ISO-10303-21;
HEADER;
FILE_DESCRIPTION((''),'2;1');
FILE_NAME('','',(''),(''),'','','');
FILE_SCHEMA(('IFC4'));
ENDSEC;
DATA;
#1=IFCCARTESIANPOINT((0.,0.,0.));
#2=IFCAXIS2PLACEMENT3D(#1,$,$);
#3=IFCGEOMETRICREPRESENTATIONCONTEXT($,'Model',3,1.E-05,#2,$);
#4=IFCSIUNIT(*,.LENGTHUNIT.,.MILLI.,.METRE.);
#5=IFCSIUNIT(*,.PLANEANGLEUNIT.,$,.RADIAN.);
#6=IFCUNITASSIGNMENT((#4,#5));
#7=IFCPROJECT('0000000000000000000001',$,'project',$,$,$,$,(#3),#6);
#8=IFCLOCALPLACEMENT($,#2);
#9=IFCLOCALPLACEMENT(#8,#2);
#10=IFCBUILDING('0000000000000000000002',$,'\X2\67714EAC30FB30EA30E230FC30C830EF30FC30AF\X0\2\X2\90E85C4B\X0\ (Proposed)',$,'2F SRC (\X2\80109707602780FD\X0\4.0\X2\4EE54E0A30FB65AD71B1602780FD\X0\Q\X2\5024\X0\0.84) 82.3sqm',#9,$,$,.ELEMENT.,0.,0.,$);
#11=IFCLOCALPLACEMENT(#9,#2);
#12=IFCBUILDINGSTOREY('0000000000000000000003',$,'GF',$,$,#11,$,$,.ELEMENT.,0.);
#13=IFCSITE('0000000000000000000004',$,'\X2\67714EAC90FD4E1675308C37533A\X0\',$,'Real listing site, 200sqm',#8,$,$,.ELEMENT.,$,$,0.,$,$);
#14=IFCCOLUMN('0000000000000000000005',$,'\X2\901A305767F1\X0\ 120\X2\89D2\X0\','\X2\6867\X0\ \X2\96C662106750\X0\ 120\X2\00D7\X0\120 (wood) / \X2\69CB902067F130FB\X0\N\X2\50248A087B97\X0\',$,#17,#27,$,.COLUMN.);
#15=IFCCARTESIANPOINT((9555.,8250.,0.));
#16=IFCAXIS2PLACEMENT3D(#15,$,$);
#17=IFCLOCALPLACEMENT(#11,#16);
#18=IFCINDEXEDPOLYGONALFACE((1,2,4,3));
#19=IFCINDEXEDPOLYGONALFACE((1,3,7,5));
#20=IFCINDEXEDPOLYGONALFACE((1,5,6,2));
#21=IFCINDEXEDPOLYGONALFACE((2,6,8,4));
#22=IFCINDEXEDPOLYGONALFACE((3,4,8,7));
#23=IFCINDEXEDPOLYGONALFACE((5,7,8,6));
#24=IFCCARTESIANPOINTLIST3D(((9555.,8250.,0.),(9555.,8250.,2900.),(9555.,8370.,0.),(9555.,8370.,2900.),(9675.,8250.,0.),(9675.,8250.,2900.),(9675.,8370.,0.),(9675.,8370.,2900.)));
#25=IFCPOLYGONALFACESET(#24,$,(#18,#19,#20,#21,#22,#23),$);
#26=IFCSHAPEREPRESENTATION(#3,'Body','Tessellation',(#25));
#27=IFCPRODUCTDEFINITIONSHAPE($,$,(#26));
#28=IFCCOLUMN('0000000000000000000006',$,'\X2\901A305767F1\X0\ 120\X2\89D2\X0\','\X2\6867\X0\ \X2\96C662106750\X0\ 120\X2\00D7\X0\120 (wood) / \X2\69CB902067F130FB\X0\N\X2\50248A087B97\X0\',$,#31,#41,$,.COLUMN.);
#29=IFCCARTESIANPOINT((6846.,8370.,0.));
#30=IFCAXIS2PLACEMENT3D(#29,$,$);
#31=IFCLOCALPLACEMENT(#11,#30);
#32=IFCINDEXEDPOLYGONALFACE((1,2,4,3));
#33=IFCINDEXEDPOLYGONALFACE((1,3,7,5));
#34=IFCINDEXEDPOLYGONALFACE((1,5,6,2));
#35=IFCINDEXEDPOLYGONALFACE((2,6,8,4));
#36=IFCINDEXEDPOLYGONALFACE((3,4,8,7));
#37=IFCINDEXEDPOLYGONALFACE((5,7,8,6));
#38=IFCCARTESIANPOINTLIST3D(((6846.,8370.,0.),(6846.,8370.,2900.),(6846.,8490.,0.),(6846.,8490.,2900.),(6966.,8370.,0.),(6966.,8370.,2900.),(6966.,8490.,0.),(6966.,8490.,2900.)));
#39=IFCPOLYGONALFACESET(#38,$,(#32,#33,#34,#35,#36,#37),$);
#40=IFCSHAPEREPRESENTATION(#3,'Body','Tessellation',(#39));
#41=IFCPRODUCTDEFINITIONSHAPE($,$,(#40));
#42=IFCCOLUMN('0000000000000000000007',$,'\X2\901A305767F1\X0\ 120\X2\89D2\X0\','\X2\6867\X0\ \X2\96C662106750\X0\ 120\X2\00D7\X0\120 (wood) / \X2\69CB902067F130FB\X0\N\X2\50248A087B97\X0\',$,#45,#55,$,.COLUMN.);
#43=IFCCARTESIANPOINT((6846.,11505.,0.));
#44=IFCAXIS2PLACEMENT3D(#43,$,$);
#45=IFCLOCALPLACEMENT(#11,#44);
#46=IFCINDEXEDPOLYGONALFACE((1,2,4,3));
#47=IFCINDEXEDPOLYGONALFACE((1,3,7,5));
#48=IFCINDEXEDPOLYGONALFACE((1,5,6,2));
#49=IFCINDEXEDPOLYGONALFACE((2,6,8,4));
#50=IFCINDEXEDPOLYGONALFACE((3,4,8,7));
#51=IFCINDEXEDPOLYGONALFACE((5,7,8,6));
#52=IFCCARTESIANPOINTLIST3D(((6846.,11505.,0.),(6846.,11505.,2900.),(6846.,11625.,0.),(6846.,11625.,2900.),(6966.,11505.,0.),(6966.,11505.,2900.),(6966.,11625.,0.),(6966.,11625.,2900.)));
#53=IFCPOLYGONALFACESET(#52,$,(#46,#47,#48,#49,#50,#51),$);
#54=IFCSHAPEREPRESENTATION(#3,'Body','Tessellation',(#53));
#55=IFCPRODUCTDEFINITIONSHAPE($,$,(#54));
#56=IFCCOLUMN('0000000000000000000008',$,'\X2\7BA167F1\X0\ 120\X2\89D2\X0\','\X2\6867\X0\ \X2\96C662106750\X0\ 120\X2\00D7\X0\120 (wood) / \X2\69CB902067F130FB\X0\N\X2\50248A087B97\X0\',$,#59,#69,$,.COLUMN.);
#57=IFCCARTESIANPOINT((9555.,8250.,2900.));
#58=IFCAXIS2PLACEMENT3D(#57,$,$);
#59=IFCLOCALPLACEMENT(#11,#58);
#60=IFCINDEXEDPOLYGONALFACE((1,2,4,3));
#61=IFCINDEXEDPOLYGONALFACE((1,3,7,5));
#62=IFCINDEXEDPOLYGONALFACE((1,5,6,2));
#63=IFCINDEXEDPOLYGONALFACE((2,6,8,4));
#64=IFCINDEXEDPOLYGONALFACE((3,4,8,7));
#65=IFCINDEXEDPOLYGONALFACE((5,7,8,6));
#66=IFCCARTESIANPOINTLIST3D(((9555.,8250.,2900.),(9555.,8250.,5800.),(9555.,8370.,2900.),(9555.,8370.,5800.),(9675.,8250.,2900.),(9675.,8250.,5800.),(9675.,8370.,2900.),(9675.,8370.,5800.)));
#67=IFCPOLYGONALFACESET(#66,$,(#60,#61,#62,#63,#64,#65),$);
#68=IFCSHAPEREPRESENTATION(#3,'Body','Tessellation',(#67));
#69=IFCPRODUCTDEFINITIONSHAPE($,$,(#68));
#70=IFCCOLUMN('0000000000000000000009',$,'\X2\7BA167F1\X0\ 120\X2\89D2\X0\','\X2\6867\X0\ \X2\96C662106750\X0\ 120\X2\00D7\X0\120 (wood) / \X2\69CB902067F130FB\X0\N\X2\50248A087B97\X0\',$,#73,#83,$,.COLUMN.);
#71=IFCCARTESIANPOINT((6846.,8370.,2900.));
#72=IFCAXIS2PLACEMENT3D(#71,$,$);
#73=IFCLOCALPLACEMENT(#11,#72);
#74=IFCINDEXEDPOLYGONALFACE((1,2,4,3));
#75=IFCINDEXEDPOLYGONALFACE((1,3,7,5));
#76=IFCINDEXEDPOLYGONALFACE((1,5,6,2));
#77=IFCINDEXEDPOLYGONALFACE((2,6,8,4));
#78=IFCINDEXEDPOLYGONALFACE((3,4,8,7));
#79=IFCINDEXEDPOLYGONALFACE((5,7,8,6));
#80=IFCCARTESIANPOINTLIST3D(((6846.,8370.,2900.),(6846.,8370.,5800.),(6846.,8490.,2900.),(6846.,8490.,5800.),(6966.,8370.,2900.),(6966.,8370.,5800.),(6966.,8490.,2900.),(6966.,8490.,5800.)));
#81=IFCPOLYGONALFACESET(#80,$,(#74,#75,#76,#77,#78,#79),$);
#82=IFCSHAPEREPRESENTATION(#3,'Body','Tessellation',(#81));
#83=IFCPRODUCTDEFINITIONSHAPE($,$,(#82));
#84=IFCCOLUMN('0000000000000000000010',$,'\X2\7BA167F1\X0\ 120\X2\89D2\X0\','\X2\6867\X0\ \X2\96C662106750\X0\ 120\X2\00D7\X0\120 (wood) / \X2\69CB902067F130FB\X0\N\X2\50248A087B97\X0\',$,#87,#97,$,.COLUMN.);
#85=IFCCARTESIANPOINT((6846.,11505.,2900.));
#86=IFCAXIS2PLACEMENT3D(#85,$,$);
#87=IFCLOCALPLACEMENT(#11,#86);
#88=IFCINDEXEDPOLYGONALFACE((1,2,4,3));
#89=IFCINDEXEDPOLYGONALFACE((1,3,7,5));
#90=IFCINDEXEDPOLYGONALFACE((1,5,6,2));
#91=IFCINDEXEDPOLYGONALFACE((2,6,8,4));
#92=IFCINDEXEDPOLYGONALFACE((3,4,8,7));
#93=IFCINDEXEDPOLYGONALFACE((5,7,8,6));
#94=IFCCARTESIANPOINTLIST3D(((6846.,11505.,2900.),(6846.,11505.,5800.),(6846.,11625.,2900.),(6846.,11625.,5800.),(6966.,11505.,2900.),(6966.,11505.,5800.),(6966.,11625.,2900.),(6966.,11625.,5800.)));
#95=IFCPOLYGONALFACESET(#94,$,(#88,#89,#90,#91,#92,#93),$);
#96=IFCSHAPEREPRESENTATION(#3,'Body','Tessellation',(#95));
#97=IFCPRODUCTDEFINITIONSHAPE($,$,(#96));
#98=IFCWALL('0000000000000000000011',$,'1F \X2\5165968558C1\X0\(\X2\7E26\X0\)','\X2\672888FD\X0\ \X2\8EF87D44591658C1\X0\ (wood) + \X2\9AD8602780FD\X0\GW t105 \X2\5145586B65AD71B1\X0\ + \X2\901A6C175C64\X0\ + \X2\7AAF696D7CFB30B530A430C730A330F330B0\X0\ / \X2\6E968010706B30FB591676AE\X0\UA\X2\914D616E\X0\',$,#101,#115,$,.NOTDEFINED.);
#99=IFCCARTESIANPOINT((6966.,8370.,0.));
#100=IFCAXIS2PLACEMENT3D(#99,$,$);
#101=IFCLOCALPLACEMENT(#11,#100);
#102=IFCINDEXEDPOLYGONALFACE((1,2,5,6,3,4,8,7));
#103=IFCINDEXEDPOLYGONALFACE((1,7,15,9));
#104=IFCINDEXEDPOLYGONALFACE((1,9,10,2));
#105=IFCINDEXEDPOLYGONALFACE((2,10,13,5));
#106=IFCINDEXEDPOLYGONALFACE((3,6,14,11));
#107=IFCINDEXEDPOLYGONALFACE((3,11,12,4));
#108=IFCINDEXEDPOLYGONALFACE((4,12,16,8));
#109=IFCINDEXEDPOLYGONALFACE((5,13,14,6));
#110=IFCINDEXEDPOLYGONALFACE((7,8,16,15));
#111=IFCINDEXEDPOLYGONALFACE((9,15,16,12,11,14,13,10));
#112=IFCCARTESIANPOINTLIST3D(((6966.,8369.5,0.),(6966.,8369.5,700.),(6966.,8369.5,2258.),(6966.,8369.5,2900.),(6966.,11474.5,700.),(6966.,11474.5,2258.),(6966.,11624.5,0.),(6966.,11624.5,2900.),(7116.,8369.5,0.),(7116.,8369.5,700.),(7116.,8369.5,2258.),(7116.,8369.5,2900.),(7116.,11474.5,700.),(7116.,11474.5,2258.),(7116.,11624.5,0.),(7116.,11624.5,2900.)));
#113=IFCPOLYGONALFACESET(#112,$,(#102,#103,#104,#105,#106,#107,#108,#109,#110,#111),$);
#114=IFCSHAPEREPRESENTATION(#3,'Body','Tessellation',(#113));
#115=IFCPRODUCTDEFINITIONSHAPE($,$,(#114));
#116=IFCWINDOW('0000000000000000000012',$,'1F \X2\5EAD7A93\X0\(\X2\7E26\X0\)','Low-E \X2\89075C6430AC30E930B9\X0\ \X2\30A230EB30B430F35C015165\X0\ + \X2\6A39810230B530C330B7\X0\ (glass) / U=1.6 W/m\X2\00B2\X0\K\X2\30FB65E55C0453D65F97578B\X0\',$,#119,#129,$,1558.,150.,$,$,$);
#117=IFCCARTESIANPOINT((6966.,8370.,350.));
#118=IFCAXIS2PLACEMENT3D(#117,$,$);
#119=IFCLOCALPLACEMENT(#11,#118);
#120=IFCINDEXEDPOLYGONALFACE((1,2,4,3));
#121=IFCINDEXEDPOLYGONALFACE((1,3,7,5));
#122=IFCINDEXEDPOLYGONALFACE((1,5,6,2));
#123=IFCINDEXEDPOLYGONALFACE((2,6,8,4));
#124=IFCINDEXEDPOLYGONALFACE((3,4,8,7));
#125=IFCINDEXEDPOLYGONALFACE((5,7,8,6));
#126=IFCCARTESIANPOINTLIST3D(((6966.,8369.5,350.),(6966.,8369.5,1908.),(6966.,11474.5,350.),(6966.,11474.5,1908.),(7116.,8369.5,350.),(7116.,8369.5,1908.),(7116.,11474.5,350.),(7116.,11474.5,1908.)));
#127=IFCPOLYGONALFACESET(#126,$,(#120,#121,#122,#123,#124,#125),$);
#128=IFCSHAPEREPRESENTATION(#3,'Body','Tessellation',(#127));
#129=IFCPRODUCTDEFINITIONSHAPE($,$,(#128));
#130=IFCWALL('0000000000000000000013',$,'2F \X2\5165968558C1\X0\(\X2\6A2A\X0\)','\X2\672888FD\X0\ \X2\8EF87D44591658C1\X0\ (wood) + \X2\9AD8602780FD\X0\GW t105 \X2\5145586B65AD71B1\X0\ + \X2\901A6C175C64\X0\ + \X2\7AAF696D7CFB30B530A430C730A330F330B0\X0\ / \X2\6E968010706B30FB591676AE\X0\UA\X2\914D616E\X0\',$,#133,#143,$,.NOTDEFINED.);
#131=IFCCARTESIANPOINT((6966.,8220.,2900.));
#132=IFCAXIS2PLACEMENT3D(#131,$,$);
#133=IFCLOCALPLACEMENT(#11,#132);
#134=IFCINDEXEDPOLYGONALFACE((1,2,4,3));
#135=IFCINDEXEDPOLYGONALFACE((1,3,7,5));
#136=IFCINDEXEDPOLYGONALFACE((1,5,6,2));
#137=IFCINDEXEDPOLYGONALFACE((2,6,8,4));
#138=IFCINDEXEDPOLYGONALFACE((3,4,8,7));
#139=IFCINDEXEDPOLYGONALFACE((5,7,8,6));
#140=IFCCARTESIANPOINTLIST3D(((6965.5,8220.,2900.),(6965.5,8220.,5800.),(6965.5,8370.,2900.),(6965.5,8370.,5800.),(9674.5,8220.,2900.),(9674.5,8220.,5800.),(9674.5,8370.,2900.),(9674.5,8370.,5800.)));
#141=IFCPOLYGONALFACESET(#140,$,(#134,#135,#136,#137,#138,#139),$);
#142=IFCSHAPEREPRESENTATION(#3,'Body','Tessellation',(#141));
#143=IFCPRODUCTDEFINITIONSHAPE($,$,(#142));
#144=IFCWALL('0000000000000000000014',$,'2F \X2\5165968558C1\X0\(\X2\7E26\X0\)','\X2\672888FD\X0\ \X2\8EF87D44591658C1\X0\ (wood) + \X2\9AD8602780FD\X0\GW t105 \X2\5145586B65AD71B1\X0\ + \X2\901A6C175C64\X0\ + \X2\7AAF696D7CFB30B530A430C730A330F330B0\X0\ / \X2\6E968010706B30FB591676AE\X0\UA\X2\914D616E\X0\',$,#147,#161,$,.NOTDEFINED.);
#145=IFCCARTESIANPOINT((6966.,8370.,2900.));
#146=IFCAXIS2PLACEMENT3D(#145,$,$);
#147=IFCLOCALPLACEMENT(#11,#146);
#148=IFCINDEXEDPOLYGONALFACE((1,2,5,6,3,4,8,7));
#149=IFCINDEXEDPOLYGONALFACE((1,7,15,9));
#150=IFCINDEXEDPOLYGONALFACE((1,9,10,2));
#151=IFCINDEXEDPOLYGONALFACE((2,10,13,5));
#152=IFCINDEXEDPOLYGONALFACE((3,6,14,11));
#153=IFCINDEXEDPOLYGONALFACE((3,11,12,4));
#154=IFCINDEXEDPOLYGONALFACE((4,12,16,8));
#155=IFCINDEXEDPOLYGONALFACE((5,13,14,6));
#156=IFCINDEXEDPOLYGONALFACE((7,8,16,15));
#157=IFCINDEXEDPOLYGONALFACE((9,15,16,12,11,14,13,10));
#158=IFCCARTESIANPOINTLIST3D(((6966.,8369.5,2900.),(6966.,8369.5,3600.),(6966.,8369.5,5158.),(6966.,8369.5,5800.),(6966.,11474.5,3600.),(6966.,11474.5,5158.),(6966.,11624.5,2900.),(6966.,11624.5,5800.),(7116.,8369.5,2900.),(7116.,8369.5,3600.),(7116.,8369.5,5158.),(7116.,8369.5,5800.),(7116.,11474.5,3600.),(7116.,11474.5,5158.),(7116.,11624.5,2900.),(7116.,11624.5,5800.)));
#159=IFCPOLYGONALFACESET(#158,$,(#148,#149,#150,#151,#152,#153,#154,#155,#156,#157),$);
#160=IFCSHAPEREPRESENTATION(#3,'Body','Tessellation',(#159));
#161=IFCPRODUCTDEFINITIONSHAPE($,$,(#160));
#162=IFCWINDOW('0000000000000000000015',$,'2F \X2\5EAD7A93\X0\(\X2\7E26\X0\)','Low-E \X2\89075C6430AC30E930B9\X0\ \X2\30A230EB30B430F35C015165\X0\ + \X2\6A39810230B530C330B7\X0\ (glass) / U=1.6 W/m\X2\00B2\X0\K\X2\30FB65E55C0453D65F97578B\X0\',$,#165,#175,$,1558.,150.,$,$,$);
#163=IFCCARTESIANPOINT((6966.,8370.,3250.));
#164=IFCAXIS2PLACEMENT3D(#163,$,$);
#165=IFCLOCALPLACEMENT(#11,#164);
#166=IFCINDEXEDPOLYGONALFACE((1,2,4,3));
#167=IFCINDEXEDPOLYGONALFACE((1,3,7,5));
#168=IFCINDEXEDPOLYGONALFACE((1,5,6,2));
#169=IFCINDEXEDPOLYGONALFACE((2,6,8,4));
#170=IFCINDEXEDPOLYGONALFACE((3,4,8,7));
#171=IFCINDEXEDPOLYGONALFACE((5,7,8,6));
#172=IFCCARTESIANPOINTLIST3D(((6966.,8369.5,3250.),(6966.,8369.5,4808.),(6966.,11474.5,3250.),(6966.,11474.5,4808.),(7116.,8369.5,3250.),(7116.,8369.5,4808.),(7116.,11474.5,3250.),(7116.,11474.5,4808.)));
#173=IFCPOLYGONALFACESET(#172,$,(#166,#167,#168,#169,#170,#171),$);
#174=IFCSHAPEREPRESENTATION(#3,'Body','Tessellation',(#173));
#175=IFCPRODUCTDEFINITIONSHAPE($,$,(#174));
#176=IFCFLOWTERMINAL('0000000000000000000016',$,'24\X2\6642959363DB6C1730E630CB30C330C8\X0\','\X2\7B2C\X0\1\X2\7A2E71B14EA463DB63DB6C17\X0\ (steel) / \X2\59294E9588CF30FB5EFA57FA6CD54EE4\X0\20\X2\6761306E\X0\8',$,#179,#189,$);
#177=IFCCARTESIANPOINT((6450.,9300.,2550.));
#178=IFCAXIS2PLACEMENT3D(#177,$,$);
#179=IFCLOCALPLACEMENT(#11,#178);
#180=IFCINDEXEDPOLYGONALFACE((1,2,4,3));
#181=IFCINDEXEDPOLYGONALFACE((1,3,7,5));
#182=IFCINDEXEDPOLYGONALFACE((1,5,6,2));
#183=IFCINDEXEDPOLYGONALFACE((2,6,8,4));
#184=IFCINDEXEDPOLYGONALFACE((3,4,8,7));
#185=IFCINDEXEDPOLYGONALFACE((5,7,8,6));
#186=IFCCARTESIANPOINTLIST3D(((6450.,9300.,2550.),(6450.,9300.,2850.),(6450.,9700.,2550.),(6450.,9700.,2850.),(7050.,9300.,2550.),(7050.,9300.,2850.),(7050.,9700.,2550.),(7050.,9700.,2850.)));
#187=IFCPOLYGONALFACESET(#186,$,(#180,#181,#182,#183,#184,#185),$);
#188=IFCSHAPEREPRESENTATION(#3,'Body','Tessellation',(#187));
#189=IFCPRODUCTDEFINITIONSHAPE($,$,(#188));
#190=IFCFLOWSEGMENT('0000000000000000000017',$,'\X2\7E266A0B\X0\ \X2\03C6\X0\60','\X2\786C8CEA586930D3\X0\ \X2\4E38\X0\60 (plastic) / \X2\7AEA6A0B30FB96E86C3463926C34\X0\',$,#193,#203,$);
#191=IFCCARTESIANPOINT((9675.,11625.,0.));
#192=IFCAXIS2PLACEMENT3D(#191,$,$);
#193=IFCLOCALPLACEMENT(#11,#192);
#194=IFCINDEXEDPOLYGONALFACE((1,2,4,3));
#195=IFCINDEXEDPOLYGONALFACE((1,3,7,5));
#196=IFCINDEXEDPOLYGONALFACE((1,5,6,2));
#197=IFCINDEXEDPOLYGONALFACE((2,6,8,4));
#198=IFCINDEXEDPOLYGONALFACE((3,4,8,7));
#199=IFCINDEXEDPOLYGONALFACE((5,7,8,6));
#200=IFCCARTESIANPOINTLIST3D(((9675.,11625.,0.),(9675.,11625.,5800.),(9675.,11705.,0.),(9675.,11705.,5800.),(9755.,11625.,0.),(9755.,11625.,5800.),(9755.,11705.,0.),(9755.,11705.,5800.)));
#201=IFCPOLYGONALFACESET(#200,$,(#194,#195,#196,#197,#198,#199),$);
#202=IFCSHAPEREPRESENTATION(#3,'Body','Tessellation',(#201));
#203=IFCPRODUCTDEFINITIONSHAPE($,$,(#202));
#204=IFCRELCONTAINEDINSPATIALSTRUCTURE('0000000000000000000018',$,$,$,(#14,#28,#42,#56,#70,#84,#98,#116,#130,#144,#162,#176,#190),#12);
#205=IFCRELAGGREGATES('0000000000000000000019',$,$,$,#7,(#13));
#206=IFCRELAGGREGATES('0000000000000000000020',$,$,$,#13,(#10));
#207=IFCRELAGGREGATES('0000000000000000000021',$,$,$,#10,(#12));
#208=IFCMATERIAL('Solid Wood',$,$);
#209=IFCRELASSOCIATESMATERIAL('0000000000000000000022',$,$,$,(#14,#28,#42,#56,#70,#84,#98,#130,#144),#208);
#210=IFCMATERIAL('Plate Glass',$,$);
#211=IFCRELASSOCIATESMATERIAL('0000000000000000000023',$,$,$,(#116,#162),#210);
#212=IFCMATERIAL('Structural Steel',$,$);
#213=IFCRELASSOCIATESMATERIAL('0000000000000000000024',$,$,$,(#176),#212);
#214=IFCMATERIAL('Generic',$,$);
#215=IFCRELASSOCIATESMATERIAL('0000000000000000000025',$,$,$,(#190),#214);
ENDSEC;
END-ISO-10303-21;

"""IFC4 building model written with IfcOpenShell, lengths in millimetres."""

from ifc_helpers import new_model, si_unit, frame, frame_2d, origin, place, context, project, spatial, rectangle, extrude, material, element, fill, save


model = new_model("IFC4")

# Units and contexts
model_context = context("Model", 3, precision=1e-05, world=origin())
ifc_project = project(units=[si_unit("LENGTHUNIT", "METRE", prefix="MILLI"), si_unit("PLANEANGLEUNIT", "RADIAN")], contexts=[model_context])

# Site, building, storey
site_placement = place(None, origin())
site = spatial("IfcSite", under=ifc_project, at=site_placement, Name="東京都世田谷区", ObjectType="Real listing site, 200sqm", CompositionType="ELEMENT", RefElevation=0.0)
building_placement = place(site_placement, origin())
building = spatial("IfcBuilding", under=site, at=building_placement, Name="東京・リモートワーク2部屋 (Proposed)", ObjectType="2F SRC (耐震性能4.0以上・断熱性能Q値0.84) 82.3sqm", CompositionType="ELEMENT", ElevationOfRefHeight=0.0, ElevationOfTerrain=0.0)
storey_placement = place(building_placement, origin())
storey = spatial("IfcBuildingStorey", under=building, at=storey_placement, Name="GF", CompositionType="ELEMENT", Elevation=0.0)

# Columns
ifc_material_1 = material(Name="Solid Wood")
column_1_placement = place(storey_placement, frame((9555.0, 8250.0, 0.0)))
element("IfcColumn", 1, at=column_1_placement, inside=storey, material=ifc_material_1, Name="通し柱 120角", Description="桧 集成材 120×120 (wood) / 構造柱・N値計算", PredefinedType="COLUMN", context=model_context, shape_type="SweptSolid", body=[
    extrude(rectangle(XDim=120.0, YDim=120.0, at=frame_2d((60.0, 60.0))), frame((9555.0, 8250.0, 0.0)), (0.0, 0.0, 1.0), 2900.0),
])
column_2_placement = place(storey_placement, frame((6846.0, 8370.0, 0.0)))
element("IfcColumn", 2, at=column_2_placement, inside=storey, material=ifc_material_1, Name="通し柱 120角", Description="桧 集成材 120×120 (wood) / 構造柱・N値計算", PredefinedType="COLUMN", context=model_context, shape_type="SweptSolid", body=[
    extrude(rectangle(XDim=120.0, YDim=120.0, at=frame_2d((60.0, 60.0))), frame((6846.0, 8370.0, 0.0)), (0.0, 0.0, 1.0), 2900.0),
])
column_3_placement = place(storey_placement, frame((6846.0, 11505.0, 0.0)))
element("IfcColumn", 3, at=column_3_placement, inside=storey, material=ifc_material_1, Name="通し柱 120角", Description="桧 集成材 120×120 (wood) / 構造柱・N値計算", PredefinedType="COLUMN", context=model_context, shape_type="SweptSolid", body=[
    extrude(rectangle(XDim=120.0, YDim=120.0, at=frame_2d((60.0, 60.0))), frame((6846.0, 11505.0, 0.0)), (0.0, 0.0, 1.0), 2900.0),
])
column_4_placement = place(storey_placement, frame((9555.0, 8250.0, 2900.0)))
element("IfcColumn", 4, at=column_4_placement, inside=storey, material=ifc_material_1, Name="管柱 120角", Description="桧 集成材 120×120 (wood) / 構造柱・N値計算", PredefinedType="COLUMN", context=model_context, shape_type="SweptSolid", body=[
    extrude(rectangle(XDim=120.0, YDim=120.0, at=frame_2d((60.0, 60.0))), frame((9555.0, 8250.0, 2900.0)), (0.0, 0.0, 1.0), 2900.0),
])
column_5_placement = place(storey_placement, frame((6846.0, 8370.0, 2900.0)))
element("IfcColumn", 5, at=column_5_placement, inside=storey, material=ifc_material_1, Name="管柱 120角", Description="桧 集成材 120×120 (wood) / 構造柱・N値計算", PredefinedType="COLUMN", context=model_context, shape_type="SweptSolid", body=[
    extrude(rectangle(XDim=120.0, YDim=120.0, at=frame_2d((60.0, 60.0))), frame((6846.0, 8370.0, 2900.0)), (0.0, 0.0, 1.0), 2900.0),
])
column_6_placement = place(storey_placement, frame((6846.0, 11505.0, 2900.0)))
element("IfcColumn", 6, at=column_6_placement, inside=storey, material=ifc_material_1, Name="管柱 120角", Description="桧 集成材 120×120 (wood) / 構造柱・N値計算", PredefinedType="COLUMN", context=model_context, shape_type="SweptSolid", body=[
    extrude(rectangle(XDim=120.0, YDim=120.0, at=frame_2d((60.0, 60.0))), frame((6846.0, 11505.0, 2900.0)), (0.0, 0.0, 1.0), 2900.0),
])

# Wall, opening, window
wall_1_placement = place(storey_placement, frame((6966.0, 8370.0, 0.0)))
wall_1 = element("IfcWall", 7, at=wall_1_placement, inside=storey, material=ifc_material_1, Name="1F 入隅壁(縦)", Description="木製 軸組外壁 (wood) + 高性能GW t105 充填断熱 + 通気層 + 窯業系サイディング / 準耐火・外皮UA配慮", PredefinedType="NOTDEFINED", context=model_context, shape_type="SweptSolid", body=[
    extrude(rectangle(XDim=150.0, YDim=3255.0, at=frame_2d((75.0, 1627.0))), frame((6966.0, 8370.0, 0.0)), (0.0, 0.0, 1.0), 2900.0),
])
opening_1_placement = place(storey_placement, frame((6966.0, 8370.0, 350.0)))
opening_1 = element("IfcOpeningElement", 8, at=opening_1_placement, cuts=wall_1, PredefinedType="NOTDEFINED", context=model_context, shape_type="SweptSolid", body=[
    extrude(rectangle(XDim=150.0, YDim=3105.0, at=frame_2d((75.0, 1552.0))), frame((6966.0, 8370.0, 350.0)), (0.0, 0.0, 1.0), 1558.0),
])
ifc_material_2 = material(Name="Plate Glass")
window_1_placement = place(storey_placement, frame((6966.0, 8370.0, 350.0)))
window_1 = element("IfcWindow", 9, at=window_1_placement, inside=storey, material=ifc_material_2, Name="1F 庭窓(縦)", Description="Low-E 複層ガラス アルゴン封入 + 樹脂サッシ (glass) / U=1.6 W/m²K・日射取得型", OverallHeight=1558.0, OverallWidth=150.0, context=model_context, shape_type="SweptSolid", body=[
    extrude(rectangle(XDim=150.0, YDim=3105.0, at=frame_2d((75.0, 1552.0))), frame((6966.0, 8370.0, 350.0)), (0.0, 0.0, 1.0), 1558.0),
])
fill(opening_1, window_1)

# Wall
wall_2_placement = place(storey_placement, frame((6966.0, 8220.0, 2900.0)))
element("IfcWall", 10, at=wall_2_placement, inside=storey, material=ifc_material_1, Name="2F 入隅壁(横)", Description="木製 軸組外壁 (wood) + 高性能GW t105 充填断熱 + 通気層 + 窯業系サイディング / 準耐火・外皮UA配慮", PredefinedType="NOTDEFINED", context=model_context, shape_type="SweptSolid", body=[
    extrude(rectangle(XDim=2709.0, YDim=150.0, at=frame_2d((1354.0, 75.0))), frame((6966.0, 8220.0, 2900.0)), (0.0, 0.0, 1.0), 2900.0),
])

# Wall, opening, window
wall_3_placement = place(storey_placement, frame((6966.0, 8370.0, 2900.0)))
wall_3 = element("IfcWall", 11, at=wall_3_placement, inside=storey, material=ifc_material_1, Name="2F 入隅壁(縦)", Description="木製 軸組外壁 (wood) + 高性能GW t105 充填断熱 + 通気層 + 窯業系サイディング / 準耐火・外皮UA配慮", PredefinedType="NOTDEFINED", context=model_context, shape_type="SweptSolid", body=[
    extrude(rectangle(XDim=150.0, YDim=3255.0, at=frame_2d((75.0, 1627.0))), frame((6966.0, 8370.0, 2900.0)), (0.0, 0.0, 1.0), 2900.0),
])
opening_2_placement = place(storey_placement, frame((6966.0, 8370.0, 3250.0)))
opening_2 = element("IfcOpeningElement", 12, at=opening_2_placement, cuts=wall_3, PredefinedType="NOTDEFINED", context=model_context, shape_type="SweptSolid", body=[
    extrude(rectangle(XDim=150.0, YDim=3105.0, at=frame_2d((75.0, 1552.0))), frame((6966.0, 8370.0, 3250.0)), (0.0, 0.0, 1.0), 1558.0),
])
window_2_placement = place(storey_placement, frame((6966.0, 8370.0, 3250.0)))
window_2 = element("IfcWindow", 13, at=window_2_placement, inside=storey, material=ifc_material_2, Name="2F 庭窓(縦)", Description="Low-E 複層ガラス アルゴン封入 + 樹脂サッシ (glass) / U=1.6 W/m²K・日射取得型", OverallHeight=1558.0, OverallWidth=150.0, context=model_context, shape_type="SweptSolid", body=[
    extrude(rectangle(XDim=150.0, YDim=3105.0, at=frame_2d((75.0, 1552.0))), frame((6966.0, 8370.0, 3250.0)), (0.0, 0.0, 1.0), 1558.0),
])
fill(opening_2, window_2)

# Flow terminal
ifc_material_3 = material(Name="Structural Steel")
flow_terminal_placement = place(storey_placement, frame((6450.0, 9300.0, 2550.0)))
element("IfcFlowTerminal", 14, at=flow_terminal_placement, inside=storey, material=ifc_material_3, Name="24時間換気ユニット", Description="第1種熱交換換気 (steel) / 天井裏・建基法令20条の8", context=model_context, shape_type="SweptSolid", body=[
    extrude(rectangle(XDim=600.0, YDim=400.0, at=frame_2d((300.0, 200.0))), frame((6450.0, 9300.0, 2550.0)), (0.0, 0.0, 1.0), 300.0),
])

# Flow segment
ifc_material_4 = material(Name="Generic")
flow_segment_placement = place(storey_placement, frame((9675.0, 11625.0, 0.0)))
element("IfcFlowSegment", 15, at=flow_segment_placement, inside=storey, material=ifc_material_4, Name="縦樋 φ60", Description="硬質塩ビ 丸60 (plastic) / 竪樋・雨水排水", context=model_context, shape_type="SweptSolid", body=[
    extrude(rectangle(XDim=80.0, YDim=80.0, at=frame_2d((40.0, 40.0))), frame((9675.0, 11625.0, 0.0)), (0.0, 0.0, 1.0), 5800.0),
])

save(model, "model.ifc")
